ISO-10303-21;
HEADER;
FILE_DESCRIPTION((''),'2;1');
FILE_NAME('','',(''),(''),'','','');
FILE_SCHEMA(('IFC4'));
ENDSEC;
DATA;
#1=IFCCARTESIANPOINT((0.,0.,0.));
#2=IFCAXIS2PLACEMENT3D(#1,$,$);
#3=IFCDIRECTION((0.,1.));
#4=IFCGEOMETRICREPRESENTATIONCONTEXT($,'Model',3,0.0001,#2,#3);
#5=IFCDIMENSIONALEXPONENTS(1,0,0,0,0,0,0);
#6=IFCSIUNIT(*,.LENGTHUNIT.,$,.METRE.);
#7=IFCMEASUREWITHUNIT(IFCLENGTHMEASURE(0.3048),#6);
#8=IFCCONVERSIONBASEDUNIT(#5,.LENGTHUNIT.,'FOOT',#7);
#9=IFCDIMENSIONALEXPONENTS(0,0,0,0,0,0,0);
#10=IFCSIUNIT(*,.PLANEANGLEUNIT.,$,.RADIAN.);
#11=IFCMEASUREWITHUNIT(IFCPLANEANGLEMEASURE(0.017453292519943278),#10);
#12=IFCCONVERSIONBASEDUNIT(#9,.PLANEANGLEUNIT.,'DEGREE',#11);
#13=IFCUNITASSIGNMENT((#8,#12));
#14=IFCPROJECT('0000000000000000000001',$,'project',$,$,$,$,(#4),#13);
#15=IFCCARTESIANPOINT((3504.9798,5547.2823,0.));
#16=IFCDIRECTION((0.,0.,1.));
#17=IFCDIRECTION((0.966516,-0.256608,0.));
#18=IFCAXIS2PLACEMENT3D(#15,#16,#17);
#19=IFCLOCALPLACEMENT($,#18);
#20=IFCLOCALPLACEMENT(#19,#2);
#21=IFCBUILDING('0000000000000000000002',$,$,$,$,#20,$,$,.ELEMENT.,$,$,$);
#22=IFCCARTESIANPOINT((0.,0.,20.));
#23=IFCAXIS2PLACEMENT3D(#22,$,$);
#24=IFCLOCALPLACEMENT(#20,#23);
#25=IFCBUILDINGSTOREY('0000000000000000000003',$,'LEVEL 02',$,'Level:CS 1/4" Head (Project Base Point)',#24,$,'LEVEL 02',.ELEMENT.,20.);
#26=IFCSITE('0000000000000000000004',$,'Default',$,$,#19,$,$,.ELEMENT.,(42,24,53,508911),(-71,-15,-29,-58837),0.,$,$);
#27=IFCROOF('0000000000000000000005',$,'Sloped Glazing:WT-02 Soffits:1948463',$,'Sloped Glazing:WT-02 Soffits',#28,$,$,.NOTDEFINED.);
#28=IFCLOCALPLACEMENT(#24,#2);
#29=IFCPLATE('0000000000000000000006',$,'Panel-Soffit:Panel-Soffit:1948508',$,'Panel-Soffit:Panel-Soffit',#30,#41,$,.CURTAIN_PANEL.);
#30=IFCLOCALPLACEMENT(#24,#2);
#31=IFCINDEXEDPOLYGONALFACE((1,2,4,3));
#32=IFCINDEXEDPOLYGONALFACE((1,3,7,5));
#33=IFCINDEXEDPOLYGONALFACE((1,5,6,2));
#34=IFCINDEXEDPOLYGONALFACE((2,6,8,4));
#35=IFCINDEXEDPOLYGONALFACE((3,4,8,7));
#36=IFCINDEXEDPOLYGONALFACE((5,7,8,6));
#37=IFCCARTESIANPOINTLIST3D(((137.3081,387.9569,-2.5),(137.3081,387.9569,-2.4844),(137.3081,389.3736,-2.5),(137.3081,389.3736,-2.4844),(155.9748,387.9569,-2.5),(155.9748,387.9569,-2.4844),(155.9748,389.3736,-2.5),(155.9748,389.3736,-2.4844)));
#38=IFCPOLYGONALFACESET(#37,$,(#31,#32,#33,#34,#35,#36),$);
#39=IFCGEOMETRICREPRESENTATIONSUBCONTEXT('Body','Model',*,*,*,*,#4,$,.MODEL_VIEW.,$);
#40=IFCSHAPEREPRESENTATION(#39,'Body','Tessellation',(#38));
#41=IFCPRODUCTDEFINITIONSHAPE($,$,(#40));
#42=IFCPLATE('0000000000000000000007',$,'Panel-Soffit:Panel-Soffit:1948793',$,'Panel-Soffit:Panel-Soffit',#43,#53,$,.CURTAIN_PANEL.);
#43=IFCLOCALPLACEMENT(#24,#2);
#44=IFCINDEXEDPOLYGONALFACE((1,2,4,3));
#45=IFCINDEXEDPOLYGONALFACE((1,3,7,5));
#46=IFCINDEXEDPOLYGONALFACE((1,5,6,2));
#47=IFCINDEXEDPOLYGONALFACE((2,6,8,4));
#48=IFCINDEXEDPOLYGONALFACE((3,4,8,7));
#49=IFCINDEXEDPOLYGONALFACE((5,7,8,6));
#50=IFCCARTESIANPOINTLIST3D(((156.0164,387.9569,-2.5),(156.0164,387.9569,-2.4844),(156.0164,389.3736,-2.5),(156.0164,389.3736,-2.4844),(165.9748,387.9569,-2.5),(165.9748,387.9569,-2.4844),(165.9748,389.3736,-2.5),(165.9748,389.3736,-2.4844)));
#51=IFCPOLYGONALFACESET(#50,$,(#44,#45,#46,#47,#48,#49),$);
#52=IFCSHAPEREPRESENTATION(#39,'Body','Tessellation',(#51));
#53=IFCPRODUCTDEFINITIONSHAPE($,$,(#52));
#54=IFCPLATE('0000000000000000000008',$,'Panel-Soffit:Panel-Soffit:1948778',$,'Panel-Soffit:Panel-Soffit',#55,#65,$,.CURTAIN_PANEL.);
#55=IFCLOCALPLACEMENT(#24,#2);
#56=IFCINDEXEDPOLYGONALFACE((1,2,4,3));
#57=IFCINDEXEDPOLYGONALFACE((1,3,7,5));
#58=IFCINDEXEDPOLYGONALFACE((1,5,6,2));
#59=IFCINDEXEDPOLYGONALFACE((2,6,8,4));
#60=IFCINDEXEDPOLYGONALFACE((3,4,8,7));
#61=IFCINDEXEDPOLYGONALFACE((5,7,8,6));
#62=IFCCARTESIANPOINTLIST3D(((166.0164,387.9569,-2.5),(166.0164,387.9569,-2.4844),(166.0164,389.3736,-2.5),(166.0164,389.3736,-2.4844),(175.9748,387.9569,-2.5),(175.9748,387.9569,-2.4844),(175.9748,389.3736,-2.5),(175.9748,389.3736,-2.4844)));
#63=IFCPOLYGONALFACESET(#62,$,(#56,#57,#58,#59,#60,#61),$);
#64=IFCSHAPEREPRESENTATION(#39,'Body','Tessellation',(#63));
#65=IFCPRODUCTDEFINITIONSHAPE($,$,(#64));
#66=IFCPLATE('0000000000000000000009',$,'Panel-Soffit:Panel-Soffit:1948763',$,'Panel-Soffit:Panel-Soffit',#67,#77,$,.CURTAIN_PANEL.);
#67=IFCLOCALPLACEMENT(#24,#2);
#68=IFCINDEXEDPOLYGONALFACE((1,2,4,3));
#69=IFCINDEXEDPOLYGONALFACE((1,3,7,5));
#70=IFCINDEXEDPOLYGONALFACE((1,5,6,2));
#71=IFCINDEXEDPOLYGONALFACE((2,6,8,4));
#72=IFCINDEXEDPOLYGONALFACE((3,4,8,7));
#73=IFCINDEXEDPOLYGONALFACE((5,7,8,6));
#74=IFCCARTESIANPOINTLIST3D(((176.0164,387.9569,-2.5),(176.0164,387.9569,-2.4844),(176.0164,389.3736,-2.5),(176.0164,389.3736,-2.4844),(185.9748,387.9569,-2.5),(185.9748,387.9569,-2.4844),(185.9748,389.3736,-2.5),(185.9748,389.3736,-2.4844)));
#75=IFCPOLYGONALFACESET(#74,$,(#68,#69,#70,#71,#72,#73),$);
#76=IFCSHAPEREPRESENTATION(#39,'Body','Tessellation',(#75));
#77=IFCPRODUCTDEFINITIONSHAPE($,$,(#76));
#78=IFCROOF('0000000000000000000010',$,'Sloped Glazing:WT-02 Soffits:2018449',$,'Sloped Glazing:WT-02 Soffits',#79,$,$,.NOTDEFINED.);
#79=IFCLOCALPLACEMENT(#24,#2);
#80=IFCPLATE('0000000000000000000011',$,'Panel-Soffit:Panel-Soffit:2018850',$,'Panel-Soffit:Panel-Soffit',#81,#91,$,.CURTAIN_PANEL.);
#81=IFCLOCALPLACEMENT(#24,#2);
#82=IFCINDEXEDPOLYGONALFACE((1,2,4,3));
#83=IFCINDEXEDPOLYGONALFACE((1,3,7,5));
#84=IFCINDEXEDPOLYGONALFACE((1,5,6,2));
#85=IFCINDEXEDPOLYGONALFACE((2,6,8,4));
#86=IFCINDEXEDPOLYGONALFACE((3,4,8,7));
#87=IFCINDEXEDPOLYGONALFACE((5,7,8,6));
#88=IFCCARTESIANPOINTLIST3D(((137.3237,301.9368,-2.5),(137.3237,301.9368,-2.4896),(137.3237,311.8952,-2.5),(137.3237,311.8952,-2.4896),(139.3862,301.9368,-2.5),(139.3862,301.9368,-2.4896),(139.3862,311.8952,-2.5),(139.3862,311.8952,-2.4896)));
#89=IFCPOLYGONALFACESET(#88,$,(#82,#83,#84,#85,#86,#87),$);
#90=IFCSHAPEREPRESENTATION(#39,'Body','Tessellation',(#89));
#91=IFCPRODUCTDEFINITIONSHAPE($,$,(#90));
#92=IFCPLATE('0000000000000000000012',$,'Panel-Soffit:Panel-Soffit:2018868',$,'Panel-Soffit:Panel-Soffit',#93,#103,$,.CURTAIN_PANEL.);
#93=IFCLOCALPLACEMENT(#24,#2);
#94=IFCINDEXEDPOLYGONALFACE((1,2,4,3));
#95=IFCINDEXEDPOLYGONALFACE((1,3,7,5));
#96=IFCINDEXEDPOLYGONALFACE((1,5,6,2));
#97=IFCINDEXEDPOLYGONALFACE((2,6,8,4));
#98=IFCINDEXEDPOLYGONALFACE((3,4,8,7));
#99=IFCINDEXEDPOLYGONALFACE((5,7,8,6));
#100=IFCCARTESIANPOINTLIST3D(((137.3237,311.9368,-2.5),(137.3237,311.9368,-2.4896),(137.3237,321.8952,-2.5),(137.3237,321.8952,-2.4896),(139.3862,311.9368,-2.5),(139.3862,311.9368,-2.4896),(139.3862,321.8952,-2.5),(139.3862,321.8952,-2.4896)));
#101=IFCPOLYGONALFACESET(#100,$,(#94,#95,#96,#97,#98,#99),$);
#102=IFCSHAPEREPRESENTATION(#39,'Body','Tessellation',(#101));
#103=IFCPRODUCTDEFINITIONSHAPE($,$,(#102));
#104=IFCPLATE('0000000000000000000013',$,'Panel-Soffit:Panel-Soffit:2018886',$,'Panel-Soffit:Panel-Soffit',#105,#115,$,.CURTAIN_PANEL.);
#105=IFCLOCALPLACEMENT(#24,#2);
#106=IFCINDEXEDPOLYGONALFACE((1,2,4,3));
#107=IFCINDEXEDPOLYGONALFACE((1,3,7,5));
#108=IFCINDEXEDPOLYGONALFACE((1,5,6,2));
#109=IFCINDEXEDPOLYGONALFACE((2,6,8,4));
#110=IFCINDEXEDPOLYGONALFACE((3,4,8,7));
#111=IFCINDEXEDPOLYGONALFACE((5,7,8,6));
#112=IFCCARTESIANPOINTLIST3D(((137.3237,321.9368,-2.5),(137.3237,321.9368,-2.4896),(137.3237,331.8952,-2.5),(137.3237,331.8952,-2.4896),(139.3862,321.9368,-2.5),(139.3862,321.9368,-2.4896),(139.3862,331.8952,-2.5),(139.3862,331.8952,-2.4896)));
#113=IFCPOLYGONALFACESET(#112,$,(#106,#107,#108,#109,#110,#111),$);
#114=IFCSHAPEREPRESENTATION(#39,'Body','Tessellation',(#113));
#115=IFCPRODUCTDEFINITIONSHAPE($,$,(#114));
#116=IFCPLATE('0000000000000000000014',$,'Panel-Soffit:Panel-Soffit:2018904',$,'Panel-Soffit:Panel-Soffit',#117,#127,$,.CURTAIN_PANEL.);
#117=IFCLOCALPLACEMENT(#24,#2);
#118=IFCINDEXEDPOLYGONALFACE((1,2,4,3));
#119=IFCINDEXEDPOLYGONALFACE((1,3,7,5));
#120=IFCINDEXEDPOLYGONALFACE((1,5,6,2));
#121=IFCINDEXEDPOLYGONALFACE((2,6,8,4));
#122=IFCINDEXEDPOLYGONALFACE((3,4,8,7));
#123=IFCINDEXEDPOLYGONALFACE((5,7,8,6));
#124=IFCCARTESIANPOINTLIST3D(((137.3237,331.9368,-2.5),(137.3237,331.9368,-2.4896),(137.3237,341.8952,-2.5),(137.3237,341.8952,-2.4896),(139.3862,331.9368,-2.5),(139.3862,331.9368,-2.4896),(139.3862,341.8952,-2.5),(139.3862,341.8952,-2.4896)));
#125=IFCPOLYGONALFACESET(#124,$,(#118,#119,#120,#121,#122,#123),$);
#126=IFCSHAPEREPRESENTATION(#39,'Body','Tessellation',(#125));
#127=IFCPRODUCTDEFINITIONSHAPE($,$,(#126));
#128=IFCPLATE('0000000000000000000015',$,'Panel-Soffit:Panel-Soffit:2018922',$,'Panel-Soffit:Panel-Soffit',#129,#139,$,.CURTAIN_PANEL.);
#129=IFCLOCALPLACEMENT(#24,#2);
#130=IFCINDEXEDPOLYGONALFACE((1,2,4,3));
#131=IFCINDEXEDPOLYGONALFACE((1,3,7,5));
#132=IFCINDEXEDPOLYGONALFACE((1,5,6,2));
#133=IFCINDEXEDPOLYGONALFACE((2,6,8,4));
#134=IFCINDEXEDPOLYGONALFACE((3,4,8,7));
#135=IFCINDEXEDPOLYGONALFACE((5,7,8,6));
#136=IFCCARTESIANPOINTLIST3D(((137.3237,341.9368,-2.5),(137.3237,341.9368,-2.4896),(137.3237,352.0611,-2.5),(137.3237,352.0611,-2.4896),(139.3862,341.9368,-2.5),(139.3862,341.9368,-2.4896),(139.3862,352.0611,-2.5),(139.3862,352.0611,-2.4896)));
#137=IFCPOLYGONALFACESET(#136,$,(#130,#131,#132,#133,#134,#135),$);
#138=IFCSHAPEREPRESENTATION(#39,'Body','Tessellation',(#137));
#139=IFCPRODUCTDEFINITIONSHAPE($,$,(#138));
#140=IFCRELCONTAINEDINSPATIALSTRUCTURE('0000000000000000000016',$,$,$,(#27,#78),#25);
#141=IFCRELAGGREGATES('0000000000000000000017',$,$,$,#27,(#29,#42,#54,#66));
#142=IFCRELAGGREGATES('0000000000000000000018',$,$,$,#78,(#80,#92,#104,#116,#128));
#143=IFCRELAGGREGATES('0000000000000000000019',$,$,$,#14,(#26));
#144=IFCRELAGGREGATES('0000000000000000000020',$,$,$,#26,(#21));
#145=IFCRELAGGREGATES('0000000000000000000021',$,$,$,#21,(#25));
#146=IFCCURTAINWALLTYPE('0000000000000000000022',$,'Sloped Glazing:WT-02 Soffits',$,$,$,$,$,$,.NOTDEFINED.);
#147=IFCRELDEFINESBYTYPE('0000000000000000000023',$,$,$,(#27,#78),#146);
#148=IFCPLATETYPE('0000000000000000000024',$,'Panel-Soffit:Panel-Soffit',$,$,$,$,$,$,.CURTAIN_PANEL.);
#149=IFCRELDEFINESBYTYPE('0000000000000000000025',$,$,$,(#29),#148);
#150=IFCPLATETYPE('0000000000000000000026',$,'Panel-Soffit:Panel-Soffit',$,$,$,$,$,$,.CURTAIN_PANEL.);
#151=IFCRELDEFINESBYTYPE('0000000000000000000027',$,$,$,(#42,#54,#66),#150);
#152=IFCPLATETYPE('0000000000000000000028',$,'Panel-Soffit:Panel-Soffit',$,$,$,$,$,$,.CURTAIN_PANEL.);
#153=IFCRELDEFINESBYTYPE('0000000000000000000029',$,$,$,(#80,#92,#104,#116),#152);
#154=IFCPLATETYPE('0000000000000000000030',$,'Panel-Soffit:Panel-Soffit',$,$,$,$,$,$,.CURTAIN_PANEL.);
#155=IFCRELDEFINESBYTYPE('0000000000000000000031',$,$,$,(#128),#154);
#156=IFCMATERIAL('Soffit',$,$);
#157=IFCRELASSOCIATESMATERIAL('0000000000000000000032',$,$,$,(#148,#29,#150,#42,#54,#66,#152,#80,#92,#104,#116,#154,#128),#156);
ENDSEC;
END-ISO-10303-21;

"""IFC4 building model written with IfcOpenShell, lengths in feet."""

from ifc_helpers import new_model, entity, si_unit, converted_unit, direction, frame, origin, place, context, subcontext, project, spatial, indexed_curve, outline, extrude, source, transform, mapped, material, type_object, type_shapes, element, aggregate, save


model = new_model("IFC4")

# Units and contexts
model_context = context("Model", 3, precision=0.0001, world=origin(), true_north=direction((0.0, 1.0)))
body_context = subcontext(model_context, "Body", "Model", "MODEL_VIEW")
ifc_project = project(units=[converted_unit("LENGTHUNIT", "FOOT", entity("IfcLengthMeasure", 0.3048), si_unit("LENGTHUNIT", "METRE"), dimensions=[1, 0, 0, 0, 0, 0, 0]), converted_unit("PLANEANGLEUNIT", "DEGREE", entity("IfcPlaneAngleMeasure", 0.017453292519943278), si_unit("PLANEANGLEUNIT", "RADIAN"), dimensions=[0, 0, 0, 0, 0, 0, 0])], contexts=[model_context])

# Site, building, storey
site_placement = place(None, frame((3504.9798, 5547.2823, 0.0), z_axis=(0.0, 0.0, 1.0), x_axis=(0.966516, -0.256608, 0.0)))
site = spatial("IfcSite", under=ifc_project, at=site_placement, Name="Default", CompositionType="ELEMENT", RefLatitude=(42, 24, 53, 508911), RefLongitude=(-71, -15, -29, -58837), RefElevation=0.0)
building_placement = place(site_placement, origin())
building = spatial("IfcBuilding", under=site, at=building_placement, CompositionType="ELEMENT")
storey_placement = place(building_placement, frame((0.0, 0.0, 20.0)))
storey = spatial("IfcBuildingStorey", under=building, at=storey_placement, Name="LEVEL 02", ObjectType="Level:CS 1/4\" Head (Project Base Point)", LongName="LEVEL 02", CompositionType="ELEMENT", Elevation=20.0)

# Roofs, plates
curtain_wall_type_1 = type_object("IfcCurtainWallType", Name="Sloped Glazing:WT-02 Soffits", PredefinedType="NOTDEFINED")
ifc_material_1 = material(Name="Soffit")
roof_1_placement = place(storey_placement, frame((0.0, 0.0, -20.0)))
roof_1 = element("IfcRoof", 1, at=roof_1_placement, inside=storey, type_object=curtain_wall_type_1, Name="Sloped Glazing:WT-02 Soffits:1948463", ObjectType="Sloped Glazing:WT-02 Soffits", PredefinedType="NOTDEFINED")
plate_type_1 = type_object("IfcPlateType", Name="Panel-Soffit:Panel-Soffit", PredefinedType="CURTAIN_PANEL", material=ifc_material_1)
shared_shape_1 = source(origin(), body_context, "Body", "SweptSolid", [
    extrude(outline(indexed_curve([(-0.0078, -9.3333), (0.0078, -9.3333), (0.0078, 9.3333), (-0.0078, 9.3333), (-0.0078, -9.3333)], self_intersect=False)), frame((0.0, -0.0078, 0.0208), z_axis=(0.0, 0.0, 1.0), x_axis=(0.0, -1.0, 0.0)), (0.0, 0.0, 1.0), 1.4167),
])
type_shapes(plate_type_1, [shared_shape_1])
plate_1_placement = place(roof_1_placement, frame((146.6414, 387.9361, 17.5), z_axis=(0.0, 1.0, 0.0), x_axis=(1.0, 0.0, 0.0)))
plate_1 = element("IfcPlate", 2, at=plate_1_placement, type_object=plate_type_1, material=ifc_material_1, Name="Panel-Soffit:Panel-Soffit:1948508", ObjectType="Panel-Soffit:Panel-Soffit", PredefinedType="CURTAIN_PANEL", context=body_context, shape_type="MappedRepresentation", body=[
    mapped(shared_shape_1, transform((0.0, 0.0, 0.0), scale=1.0)),
])
plate_type_2 = type_object("IfcPlateType", Name="Panel-Soffit:Panel-Soffit", PredefinedType="CURTAIN_PANEL", material=ifc_material_1)
shared_shape_2 = source(origin(), body_context, "Body", "SweptSolid", [
    extrude(outline(indexed_curve([(-0.0078, -4.9792), (0.0078, -4.9792), (0.0078, 4.9792), (-0.0078, 4.9792), (-0.0078, -4.9792)], self_intersect=False)), frame((0.0, -0.0078, 0.0208), z_axis=(0.0, 0.0, 1.0), x_axis=(0.0, -1.0, 0.0)), (0.0, 0.0, 1.0), 1.4167),
])
type_shapes(plate_type_2, [shared_shape_2])
plate_2_placement = place(roof_1_placement, frame((160.9956, 387.9361, 17.5), z_axis=(0.0, 1.0, 0.0), x_axis=(1.0, 0.0, 0.0)))
plate_2 = element("IfcPlate", 3, at=plate_2_placement, type_object=plate_type_2, material=ifc_material_1, Name="Panel-Soffit:Panel-Soffit:1948793", ObjectType="Panel-Soffit:Panel-Soffit", PredefinedType="CURTAIN_PANEL", context=body_context, shape_type="MappedRepresentation", body=[
    mapped(shared_shape_2, transform((0.0, 0.0, 0.0), scale=1.0)),
])
plate_3_placement = place(roof_1_placement, frame((170.9956, 387.9361, 17.5), z_axis=(0.0, 1.0, 0.0), x_axis=(1.0, 0.0, 0.0)))
plate_3 = element("IfcPlate", 4, at=plate_3_placement, type_object=plate_type_2, material=ifc_material_1, Name="Panel-Soffit:Panel-Soffit:1948778", ObjectType="Panel-Soffit:Panel-Soffit", PredefinedType="CURTAIN_PANEL", context=body_context, shape_type="MappedRepresentation", body=[
    mapped(shared_shape_2, transform((0.0, 0.0, 0.0), scale=1.0)),
])
plate_4_placement = place(roof_1_placement, frame((180.9956, 387.9361, 17.5), z_axis=(0.0, 1.0, 0.0), x_axis=(1.0, 0.0, 0.0)))
plate_4 = element("IfcPlate", 5, at=plate_4_placement, type_object=plate_type_2, material=ifc_material_1, Name="Panel-Soffit:Panel-Soffit:1948763", ObjectType="Panel-Soffit:Panel-Soffit", PredefinedType="CURTAIN_PANEL", context=body_context, shape_type="MappedRepresentation", body=[
    mapped(shared_shape_2, transform((0.0, 0.0, 0.0), scale=1.0)),
])
aggregate(roof_1, [plate_1, plate_2, plate_3, plate_4])
roof_2_placement = place(storey_placement, frame((0.0, 0.0, -20.0)))
roof_2 = element("IfcRoof", 6, at=roof_2_placement, inside=storey, type_object=curtain_wall_type_1, Name="Sloped Glazing:WT-02 Soffits:2018449", ObjectType="Sloped Glazing:WT-02 Soffits", PredefinedType="NOTDEFINED")
plate_type_3 = type_object("IfcPlateType", Name="Panel-Soffit:Panel-Soffit", PredefinedType="CURTAIN_PANEL", material=ifc_material_1)
shared_shape_3 = source(origin(), body_context, "Body", "SweptSolid", [
    extrude(outline(indexed_curve([(-0.0052, -1.0313), (0.0052, -1.0313), (0.0052, 1.0313), (-0.0052, 1.0313), (-0.0052, -1.0313)], self_intersect=False)), frame((0.0, -0.0052, 0.0208), z_axis=(0.0, 0.0, 1.0), x_axis=(0.0, -1.0, 0.0)), (0.0, 0.0, 1.0), 9.9583),
])
type_shapes(plate_type_3, [shared_shape_3])
plate_5_placement = place(roof_2_placement, frame((138.355, 301.916, 17.5), z_axis=(0.0, 1.0, 0.0), x_axis=(1.0, 0.0, 0.0)))
plate_5 = element("IfcPlate", 7, at=plate_5_placement, type_object=plate_type_3, material=ifc_material_1, Name="Panel-Soffit:Panel-Soffit:2018850", ObjectType="Panel-Soffit:Panel-Soffit", PredefinedType="CURTAIN_PANEL", context=body_context, shape_type="MappedRepresentation", body=[
    mapped(shared_shape_3, transform((0.0, 0.0, 0.0), scale=1.0)),
])
plate_6_placement = place(roof_2_placement, frame((138.355, 311.916, 17.5), z_axis=(0.0, 1.0, 0.0), x_axis=(1.0, 0.0, 0.0)))
plate_6 = element("IfcPlate", 8, at=plate_6_placement, type_object=plate_type_3, material=ifc_material_1, Name="Panel-Soffit:Panel-Soffit:2018868", ObjectType="Panel-Soffit:Panel-Soffit", PredefinedType="CURTAIN_PANEL", context=body_context, shape_type="MappedRepresentation", body=[
    mapped(shared_shape_3, transform((0.0, 0.0, 0.0), scale=1.0)),
])
plate_7_placement = place(roof_2_placement, frame((138.355, 321.916, 17.5), z_axis=(0.0, 1.0, 0.0), x_axis=(1.0, 0.0, 0.0)))
plate_7 = element("IfcPlate", 9, at=plate_7_placement, type_object=plate_type_3, material=ifc_material_1, Name="Panel-Soffit:Panel-Soffit:2018886", ObjectType="Panel-Soffit:Panel-Soffit", PredefinedType="CURTAIN_PANEL", context=body_context, shape_type="MappedRepresentation", body=[
    mapped(shared_shape_3, transform((0.0, 0.0, 0.0), scale=1.0)),
])
plate_8_placement = place(roof_2_placement, frame((138.355, 331.916, 17.5), z_axis=(0.0, 1.0, 0.0), x_axis=(1.0, 0.0, 0.0)))
plate_8 = element("IfcPlate", 10, at=plate_8_placement, type_object=plate_type_3, material=ifc_material_1, Name="Panel-Soffit:Panel-Soffit:2018904", ObjectType="Panel-Soffit:Panel-Soffit", PredefinedType="CURTAIN_PANEL", context=body_context, shape_type="MappedRepresentation", body=[
    mapped(shared_shape_3, transform((0.0, 0.0, 0.0), scale=1.0)),
])
plate_type_4 = type_object("IfcPlateType", Name="Panel-Soffit:Panel-Soffit", PredefinedType="CURTAIN_PANEL", material=ifc_material_1)
shared_shape_4 = source(origin(), body_context, "Body", "SweptSolid", [
    extrude(outline(indexed_curve([(-0.0052, -1.0313), (0.0052, -1.0313), (0.0052, 1.0313), (-0.0052, 1.0313), (-0.0052, -1.0313)], self_intersect=False)), frame((0.0, -0.0052, 0.0208), z_axis=(0.0, 0.0, 1.0), x_axis=(0.0, -1.0, 0.0)), (0.0, 0.0, 1.0), 10.1242),
])
type_shapes(plate_type_4, [shared_shape_4])
plate_9_placement = place(roof_2_placement, frame((138.355, 341.916, 17.5), z_axis=(0.0, 1.0, 0.0), x_axis=(1.0, 0.0, 0.0)))
plate_9 = element("IfcPlate", 11, at=plate_9_placement, type_object=plate_type_4, material=ifc_material_1, Name="Panel-Soffit:Panel-Soffit:2018922", ObjectType="Panel-Soffit:Panel-Soffit", PredefinedType="CURTAIN_PANEL", context=body_context, shape_type="MappedRepresentation", body=[
    mapped(shared_shape_4, transform((0.0, 0.0, 0.0), scale=1.0)),
])
aggregate(roof_2, [plate_5, plate_6, plate_7, plate_8, plate_9])

save(model, "model.ifc")
